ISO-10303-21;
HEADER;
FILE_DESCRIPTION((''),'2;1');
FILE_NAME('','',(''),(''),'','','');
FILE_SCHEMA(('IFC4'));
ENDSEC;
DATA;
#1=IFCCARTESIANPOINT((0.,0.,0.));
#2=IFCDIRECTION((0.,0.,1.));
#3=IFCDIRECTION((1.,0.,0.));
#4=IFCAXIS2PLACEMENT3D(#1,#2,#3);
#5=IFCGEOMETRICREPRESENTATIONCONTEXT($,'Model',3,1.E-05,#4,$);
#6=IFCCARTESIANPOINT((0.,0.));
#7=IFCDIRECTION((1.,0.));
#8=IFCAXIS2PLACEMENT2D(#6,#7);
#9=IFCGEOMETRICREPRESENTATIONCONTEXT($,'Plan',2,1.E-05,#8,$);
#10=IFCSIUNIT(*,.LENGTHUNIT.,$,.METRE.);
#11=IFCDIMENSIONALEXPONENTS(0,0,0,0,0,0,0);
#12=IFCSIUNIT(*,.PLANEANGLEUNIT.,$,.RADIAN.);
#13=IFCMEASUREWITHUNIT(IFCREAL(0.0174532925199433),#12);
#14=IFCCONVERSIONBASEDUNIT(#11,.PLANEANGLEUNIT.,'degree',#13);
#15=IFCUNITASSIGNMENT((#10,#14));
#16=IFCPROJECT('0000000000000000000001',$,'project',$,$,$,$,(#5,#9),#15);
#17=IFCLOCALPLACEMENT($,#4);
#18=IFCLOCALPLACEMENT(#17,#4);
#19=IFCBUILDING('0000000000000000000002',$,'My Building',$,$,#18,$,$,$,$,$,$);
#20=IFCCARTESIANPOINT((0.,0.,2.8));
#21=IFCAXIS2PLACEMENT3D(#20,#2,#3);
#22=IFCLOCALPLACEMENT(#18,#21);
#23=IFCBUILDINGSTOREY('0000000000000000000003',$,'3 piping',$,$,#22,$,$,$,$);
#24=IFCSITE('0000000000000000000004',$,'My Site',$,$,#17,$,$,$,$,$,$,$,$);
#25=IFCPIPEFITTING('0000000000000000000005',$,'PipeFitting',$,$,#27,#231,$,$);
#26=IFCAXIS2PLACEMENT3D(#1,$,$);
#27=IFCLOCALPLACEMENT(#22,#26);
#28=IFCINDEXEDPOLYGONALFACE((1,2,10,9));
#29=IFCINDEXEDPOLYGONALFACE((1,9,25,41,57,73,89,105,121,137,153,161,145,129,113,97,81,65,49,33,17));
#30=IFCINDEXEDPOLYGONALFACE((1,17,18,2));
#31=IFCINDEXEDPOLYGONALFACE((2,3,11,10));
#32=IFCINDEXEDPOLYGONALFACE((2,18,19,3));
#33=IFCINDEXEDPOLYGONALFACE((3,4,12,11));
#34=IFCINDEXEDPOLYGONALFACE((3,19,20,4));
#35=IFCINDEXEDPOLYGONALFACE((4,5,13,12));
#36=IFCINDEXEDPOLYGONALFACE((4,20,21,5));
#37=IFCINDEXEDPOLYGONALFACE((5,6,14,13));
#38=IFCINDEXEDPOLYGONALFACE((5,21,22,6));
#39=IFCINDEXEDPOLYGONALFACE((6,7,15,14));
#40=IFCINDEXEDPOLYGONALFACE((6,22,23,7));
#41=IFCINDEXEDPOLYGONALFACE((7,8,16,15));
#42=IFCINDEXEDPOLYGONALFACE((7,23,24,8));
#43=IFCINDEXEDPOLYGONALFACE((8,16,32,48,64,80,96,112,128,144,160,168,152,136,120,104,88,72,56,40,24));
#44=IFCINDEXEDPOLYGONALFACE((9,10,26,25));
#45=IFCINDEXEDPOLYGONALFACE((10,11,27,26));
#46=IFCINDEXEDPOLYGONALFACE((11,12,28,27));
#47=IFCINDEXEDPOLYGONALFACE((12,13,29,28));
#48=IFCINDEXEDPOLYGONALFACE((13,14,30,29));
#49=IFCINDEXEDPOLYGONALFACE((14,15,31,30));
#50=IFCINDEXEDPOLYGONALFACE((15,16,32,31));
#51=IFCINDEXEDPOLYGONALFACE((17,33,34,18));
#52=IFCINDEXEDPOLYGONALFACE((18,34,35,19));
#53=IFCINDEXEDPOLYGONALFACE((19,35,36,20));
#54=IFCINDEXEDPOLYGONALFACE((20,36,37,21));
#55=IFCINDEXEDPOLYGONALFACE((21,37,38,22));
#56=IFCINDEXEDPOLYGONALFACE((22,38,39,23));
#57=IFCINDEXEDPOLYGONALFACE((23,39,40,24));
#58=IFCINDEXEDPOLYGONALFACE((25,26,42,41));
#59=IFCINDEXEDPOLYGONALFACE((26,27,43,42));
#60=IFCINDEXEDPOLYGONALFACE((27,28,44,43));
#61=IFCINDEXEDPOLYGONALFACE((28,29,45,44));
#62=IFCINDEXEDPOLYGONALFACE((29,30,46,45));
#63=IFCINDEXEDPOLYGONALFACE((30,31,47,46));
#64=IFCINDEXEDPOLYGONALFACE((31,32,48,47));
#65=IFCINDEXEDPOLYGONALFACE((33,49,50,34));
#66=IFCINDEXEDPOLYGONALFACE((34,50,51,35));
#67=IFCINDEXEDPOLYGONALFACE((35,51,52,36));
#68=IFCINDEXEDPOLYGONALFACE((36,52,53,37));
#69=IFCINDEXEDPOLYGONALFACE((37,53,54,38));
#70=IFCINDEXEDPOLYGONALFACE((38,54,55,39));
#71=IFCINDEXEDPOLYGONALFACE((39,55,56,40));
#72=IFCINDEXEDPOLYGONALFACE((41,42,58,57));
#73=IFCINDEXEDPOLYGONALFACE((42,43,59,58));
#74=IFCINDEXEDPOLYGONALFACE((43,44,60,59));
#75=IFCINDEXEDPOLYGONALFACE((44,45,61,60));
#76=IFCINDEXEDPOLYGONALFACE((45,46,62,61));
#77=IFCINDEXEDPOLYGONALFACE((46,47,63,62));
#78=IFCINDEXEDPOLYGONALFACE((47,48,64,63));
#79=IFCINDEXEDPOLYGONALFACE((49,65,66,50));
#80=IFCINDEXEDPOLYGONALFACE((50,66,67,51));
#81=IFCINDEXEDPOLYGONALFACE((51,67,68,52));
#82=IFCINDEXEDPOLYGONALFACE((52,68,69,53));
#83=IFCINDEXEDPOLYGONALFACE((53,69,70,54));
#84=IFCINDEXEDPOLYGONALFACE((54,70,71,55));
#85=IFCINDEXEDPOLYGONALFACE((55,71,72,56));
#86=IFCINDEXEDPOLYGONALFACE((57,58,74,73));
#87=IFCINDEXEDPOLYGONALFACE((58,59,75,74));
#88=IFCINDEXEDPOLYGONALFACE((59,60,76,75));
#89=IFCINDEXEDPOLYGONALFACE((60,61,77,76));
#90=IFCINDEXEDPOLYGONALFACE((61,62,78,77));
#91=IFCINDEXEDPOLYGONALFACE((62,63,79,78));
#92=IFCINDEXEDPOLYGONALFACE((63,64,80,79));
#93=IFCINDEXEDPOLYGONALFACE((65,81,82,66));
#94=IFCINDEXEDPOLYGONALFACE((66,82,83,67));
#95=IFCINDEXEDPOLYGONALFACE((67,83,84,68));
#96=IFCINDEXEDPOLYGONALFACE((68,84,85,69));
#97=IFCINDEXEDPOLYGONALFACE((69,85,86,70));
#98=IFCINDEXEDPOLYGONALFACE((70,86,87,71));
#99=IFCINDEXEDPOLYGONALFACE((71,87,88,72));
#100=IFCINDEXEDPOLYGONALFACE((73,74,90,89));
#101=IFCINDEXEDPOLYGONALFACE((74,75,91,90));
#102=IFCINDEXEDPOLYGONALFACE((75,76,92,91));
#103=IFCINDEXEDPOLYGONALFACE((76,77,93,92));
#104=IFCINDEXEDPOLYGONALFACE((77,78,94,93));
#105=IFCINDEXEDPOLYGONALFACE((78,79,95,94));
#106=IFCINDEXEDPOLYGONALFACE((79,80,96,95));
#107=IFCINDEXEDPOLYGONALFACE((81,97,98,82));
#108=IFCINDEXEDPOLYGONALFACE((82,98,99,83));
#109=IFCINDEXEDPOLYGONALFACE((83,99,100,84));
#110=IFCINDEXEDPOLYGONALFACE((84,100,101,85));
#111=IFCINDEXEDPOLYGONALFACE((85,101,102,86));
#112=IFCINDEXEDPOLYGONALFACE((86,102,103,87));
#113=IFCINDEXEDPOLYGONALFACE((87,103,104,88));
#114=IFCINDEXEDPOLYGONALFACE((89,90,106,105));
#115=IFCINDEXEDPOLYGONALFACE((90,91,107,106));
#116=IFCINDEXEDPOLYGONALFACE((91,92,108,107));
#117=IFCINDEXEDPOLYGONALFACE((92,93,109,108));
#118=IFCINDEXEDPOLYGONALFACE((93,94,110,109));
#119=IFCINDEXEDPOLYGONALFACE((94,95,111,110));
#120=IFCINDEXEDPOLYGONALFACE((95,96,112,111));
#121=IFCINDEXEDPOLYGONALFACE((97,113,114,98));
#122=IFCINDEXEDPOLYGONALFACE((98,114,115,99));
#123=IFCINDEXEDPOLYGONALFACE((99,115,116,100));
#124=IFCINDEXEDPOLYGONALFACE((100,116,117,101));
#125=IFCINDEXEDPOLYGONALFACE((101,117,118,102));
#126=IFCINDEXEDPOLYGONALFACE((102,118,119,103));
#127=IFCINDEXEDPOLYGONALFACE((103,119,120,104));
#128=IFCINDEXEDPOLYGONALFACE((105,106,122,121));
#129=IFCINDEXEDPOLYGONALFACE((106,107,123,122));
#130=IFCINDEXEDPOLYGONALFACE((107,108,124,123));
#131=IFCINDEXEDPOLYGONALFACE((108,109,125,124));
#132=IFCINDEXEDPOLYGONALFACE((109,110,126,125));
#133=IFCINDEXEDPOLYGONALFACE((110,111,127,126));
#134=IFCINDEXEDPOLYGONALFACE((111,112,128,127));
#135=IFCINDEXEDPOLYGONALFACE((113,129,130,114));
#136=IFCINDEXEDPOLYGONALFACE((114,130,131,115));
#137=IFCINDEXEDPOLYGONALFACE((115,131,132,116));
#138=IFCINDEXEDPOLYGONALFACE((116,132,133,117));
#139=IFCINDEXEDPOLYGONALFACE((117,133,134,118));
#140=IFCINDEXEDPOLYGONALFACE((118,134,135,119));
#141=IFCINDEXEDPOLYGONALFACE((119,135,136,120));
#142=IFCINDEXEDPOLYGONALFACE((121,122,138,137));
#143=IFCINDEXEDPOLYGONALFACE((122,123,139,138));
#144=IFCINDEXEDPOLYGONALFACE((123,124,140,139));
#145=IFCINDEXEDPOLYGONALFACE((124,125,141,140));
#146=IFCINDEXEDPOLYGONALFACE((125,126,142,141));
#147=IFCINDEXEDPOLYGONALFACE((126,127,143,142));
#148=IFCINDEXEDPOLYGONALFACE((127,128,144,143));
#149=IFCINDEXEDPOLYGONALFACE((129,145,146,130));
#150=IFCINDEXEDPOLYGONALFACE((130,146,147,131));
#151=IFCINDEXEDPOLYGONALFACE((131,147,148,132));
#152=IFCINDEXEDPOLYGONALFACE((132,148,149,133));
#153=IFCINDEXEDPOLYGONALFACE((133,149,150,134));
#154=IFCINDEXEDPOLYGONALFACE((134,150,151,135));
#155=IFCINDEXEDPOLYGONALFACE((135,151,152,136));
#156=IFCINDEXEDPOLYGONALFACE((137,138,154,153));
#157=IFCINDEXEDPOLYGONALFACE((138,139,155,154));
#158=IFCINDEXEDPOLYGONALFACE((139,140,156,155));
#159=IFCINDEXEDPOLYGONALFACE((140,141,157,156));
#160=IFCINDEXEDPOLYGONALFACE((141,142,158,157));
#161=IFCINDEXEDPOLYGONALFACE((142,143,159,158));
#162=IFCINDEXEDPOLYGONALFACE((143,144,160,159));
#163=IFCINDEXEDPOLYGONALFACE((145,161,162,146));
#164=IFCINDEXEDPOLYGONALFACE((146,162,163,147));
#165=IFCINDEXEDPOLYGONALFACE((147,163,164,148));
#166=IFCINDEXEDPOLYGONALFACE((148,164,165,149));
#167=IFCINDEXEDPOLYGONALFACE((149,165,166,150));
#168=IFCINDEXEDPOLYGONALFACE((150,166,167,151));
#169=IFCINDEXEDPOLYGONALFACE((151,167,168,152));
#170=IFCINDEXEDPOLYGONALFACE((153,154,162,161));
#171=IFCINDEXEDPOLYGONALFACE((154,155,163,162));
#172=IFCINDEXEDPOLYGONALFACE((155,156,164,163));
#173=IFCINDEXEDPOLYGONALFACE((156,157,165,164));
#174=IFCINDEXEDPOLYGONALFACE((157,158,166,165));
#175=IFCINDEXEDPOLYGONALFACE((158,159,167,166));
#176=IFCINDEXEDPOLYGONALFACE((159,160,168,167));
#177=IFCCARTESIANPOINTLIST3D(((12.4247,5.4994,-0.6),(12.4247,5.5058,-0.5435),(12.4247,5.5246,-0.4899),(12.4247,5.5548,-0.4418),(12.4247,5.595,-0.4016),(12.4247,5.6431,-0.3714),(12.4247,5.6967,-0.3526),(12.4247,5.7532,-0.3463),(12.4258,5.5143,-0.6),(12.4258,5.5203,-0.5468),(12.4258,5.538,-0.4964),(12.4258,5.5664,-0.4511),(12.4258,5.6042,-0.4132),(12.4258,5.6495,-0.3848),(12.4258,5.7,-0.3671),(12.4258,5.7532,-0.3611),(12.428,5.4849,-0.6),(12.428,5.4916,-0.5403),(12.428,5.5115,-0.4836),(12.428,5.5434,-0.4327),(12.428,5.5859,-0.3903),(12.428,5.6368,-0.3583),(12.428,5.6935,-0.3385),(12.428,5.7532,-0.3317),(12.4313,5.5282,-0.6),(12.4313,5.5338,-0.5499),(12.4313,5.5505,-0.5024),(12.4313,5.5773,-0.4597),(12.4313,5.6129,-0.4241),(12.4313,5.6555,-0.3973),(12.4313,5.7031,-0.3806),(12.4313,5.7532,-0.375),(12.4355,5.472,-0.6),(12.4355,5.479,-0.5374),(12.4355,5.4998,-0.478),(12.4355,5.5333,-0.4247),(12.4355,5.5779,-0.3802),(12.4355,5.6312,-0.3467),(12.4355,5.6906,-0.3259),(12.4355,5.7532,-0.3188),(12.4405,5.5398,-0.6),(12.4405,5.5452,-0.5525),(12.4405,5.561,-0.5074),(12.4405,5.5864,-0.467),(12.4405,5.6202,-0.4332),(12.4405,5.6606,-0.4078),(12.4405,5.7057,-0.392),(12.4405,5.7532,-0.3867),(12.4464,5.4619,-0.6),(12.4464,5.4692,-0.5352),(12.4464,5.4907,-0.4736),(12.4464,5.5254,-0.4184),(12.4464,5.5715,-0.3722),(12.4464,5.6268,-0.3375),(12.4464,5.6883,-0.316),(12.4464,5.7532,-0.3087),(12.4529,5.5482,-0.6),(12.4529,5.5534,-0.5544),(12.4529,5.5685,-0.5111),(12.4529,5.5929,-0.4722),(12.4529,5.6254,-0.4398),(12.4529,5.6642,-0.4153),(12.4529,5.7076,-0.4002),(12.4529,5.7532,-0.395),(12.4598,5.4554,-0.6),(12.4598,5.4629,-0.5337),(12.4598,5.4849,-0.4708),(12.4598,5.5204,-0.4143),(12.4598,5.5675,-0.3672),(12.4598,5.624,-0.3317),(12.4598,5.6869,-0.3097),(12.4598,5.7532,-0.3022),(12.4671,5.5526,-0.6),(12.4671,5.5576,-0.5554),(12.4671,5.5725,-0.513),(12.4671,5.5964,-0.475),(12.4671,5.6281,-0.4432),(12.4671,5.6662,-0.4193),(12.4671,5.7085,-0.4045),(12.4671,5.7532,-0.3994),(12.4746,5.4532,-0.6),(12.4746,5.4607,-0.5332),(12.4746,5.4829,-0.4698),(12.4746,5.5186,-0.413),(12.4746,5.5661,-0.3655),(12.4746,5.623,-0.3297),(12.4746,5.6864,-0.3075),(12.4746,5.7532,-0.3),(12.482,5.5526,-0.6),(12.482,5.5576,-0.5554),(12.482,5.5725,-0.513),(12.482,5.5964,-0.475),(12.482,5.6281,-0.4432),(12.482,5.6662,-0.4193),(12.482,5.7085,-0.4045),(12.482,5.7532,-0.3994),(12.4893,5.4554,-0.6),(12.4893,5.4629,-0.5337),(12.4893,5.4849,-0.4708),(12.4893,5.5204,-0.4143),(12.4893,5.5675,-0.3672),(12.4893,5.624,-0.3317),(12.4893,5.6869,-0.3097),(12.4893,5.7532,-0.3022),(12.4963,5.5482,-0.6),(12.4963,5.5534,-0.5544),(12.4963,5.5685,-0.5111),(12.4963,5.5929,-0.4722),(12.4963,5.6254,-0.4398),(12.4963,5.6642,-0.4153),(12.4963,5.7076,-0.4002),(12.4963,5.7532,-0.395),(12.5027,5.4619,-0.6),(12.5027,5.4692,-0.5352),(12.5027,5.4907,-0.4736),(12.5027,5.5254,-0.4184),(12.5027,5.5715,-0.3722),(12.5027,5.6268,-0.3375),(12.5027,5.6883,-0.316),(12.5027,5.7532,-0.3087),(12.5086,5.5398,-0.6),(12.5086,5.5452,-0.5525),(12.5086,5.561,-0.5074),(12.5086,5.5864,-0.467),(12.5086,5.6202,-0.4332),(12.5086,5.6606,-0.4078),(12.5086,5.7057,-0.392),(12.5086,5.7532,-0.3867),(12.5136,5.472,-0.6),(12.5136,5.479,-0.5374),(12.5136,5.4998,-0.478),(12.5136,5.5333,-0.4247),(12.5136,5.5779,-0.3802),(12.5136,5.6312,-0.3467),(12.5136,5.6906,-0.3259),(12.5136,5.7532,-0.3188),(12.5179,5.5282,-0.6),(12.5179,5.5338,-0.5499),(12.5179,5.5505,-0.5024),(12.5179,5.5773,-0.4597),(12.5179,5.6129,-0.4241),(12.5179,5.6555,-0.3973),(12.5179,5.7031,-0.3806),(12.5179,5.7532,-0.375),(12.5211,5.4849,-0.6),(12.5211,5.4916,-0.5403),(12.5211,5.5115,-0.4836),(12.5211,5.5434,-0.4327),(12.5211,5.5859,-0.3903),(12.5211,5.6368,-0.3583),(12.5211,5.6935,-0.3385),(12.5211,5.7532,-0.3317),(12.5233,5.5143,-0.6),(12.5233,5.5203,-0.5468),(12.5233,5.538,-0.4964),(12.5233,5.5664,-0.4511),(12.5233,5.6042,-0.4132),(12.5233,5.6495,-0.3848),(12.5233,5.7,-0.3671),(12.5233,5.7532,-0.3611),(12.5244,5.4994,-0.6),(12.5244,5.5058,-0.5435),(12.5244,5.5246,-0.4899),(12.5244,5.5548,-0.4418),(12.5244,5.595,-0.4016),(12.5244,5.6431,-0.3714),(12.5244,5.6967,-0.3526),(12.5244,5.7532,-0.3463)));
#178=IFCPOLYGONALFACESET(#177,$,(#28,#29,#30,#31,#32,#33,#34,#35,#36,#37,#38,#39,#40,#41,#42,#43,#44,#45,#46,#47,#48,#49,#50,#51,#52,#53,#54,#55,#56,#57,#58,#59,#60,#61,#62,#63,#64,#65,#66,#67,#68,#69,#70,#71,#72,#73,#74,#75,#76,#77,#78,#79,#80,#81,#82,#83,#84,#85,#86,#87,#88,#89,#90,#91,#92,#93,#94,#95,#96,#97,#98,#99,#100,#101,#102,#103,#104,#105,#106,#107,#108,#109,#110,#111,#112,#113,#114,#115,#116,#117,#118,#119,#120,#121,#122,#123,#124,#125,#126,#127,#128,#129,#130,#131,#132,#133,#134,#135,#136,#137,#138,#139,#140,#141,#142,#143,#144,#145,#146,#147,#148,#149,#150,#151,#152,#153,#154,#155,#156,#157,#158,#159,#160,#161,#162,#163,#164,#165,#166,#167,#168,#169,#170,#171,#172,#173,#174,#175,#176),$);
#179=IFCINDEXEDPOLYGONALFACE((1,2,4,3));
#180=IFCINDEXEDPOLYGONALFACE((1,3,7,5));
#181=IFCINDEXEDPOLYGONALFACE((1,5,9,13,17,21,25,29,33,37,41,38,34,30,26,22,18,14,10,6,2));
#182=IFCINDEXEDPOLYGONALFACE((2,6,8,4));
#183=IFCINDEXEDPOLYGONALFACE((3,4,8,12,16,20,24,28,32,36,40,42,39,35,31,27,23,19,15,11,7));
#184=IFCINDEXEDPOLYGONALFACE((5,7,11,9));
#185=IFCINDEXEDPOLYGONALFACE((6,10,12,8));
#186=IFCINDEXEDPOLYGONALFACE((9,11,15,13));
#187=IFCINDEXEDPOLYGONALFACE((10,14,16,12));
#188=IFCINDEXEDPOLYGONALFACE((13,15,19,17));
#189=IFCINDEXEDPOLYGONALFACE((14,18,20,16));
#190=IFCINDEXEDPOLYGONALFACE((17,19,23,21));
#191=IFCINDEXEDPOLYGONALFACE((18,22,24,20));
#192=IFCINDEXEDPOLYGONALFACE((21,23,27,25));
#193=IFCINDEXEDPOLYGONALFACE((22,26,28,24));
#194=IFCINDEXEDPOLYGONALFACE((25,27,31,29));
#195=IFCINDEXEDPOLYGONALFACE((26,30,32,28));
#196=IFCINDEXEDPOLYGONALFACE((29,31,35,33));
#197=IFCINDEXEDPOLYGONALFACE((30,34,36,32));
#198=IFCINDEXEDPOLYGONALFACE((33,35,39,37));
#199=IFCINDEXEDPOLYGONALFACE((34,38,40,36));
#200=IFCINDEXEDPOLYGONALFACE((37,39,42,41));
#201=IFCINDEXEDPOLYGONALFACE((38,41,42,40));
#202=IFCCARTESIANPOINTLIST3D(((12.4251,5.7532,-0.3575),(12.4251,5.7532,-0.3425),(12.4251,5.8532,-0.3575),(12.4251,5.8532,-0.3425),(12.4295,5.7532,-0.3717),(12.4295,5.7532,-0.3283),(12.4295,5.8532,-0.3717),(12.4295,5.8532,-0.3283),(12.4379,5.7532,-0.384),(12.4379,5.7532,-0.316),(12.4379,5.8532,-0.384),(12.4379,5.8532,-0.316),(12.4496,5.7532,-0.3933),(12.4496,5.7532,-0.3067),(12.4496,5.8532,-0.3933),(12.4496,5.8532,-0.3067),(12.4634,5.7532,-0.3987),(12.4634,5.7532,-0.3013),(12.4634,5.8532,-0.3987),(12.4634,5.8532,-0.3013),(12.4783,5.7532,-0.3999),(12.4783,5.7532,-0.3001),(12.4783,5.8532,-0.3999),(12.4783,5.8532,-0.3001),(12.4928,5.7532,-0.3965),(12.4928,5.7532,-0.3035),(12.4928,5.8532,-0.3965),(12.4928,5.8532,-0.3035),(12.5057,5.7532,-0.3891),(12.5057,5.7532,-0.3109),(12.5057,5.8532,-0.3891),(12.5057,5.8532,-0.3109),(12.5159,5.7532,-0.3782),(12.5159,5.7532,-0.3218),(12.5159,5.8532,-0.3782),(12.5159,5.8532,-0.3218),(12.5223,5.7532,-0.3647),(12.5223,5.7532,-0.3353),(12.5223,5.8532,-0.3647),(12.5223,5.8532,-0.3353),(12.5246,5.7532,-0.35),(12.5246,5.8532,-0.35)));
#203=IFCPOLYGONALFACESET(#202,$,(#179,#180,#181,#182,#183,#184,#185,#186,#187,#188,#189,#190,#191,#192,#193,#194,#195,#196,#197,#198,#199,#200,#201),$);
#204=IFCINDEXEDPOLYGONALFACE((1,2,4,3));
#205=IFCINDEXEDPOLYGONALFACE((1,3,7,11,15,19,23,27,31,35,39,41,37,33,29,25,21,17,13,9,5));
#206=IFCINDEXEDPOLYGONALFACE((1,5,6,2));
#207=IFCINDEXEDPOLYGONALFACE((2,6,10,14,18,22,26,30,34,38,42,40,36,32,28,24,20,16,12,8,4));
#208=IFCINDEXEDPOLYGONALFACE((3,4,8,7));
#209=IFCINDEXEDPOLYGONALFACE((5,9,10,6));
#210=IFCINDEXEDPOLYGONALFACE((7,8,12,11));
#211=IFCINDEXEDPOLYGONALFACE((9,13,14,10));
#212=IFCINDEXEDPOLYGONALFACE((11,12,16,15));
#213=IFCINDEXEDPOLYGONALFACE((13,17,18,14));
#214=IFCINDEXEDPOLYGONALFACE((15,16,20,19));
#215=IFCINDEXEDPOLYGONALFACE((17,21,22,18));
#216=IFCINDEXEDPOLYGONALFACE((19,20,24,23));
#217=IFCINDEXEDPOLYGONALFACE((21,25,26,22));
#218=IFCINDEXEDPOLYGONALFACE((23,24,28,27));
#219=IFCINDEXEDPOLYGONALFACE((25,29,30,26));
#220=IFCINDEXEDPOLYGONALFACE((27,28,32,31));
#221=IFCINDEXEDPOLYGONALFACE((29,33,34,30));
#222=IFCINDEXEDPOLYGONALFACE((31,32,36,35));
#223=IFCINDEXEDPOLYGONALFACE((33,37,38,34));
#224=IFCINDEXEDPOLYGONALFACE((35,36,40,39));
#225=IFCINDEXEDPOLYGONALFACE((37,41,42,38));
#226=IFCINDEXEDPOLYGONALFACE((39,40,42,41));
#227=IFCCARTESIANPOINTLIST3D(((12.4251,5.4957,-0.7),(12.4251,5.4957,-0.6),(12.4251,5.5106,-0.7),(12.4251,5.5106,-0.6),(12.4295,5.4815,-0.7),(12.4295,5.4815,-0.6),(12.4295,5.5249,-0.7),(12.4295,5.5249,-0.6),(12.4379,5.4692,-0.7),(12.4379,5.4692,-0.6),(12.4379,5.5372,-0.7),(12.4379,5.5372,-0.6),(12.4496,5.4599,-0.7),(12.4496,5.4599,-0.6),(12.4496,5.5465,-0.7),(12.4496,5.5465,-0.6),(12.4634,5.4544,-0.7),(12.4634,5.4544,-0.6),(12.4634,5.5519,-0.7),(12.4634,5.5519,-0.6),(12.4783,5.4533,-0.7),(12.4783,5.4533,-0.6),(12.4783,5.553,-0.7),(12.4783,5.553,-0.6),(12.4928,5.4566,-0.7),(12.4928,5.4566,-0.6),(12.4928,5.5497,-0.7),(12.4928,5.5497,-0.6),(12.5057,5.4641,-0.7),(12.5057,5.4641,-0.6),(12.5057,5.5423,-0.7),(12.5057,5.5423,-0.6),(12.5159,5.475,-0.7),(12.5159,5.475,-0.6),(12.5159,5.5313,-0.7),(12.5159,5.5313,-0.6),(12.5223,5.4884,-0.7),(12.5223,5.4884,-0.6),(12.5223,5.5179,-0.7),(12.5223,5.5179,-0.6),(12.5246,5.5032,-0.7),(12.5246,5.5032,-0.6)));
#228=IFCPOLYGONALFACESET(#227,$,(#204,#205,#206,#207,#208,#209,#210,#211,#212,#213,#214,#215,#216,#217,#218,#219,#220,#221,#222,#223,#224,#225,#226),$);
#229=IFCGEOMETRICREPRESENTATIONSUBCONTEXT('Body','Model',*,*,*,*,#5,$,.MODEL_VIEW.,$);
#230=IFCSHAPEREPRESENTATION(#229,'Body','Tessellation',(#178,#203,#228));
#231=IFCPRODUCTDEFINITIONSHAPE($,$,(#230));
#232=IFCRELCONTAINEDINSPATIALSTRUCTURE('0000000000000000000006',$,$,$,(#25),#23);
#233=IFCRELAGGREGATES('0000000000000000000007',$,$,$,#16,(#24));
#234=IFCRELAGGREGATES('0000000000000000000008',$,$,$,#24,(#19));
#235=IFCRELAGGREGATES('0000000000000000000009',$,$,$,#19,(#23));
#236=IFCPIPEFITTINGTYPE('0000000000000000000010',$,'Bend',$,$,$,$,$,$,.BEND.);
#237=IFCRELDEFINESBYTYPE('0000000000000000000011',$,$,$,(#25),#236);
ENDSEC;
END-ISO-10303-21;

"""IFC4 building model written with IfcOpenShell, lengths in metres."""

from ifc_helpers import new_model, entity, si_unit, converted_unit, frame, origin_with_axes, origin_2d_with_axis, place, context, subcontext, project, spatial, circle, extrude, source, transform, mapped, type_object, type_shapes, element, save


model = new_model("IFC4")

# Units and contexts
model_context = context("Model", 3, precision=1e-05, world=origin_with_axes())
plan_context = context("Plan", 2, precision=1e-05, world=origin_2d_with_axis())
body_context = subcontext(model_context, "Body", "Model", "MODEL_VIEW")
ifc_project = project(units=[si_unit("LENGTHUNIT", "METRE"), converted_unit("PLANEANGLEUNIT", "degree", entity("IfcReal", 0.0174532925199433), si_unit("PLANEANGLEUNIT", "RADIAN"), dimensions=[0, 0, 0, 0, 0, 0, 0])], contexts=[model_context, plan_context])

# Site, building, storey
site_placement = place(None, origin_with_axes())
site = spatial("IfcSite", under=ifc_project, at=site_placement, Name="My Site")
building_placement = place(site_placement, origin_with_axes())
building = spatial("IfcBuilding", under=site, at=building_placement, Name="My Building")
storey_placement = place(building_placement, frame((0.0, 0.0, 2.8), z_axis=(0.0, 0.0, 1.0), x_axis=(1.0, 0.0, 0.0)))
storey = spatial("IfcBuildingStorey", under=building, at=storey_placement, Name="3 piping")

# Pipe fitting
pipe_fitting_type_1 = type_object("IfcPipeFittingType", Name="Bend", PredefinedType="BEND")
shared_shape = source(origin_with_axes(), body_context, "Body", "SolidModel", [
    entity("IfcSweptDiskSolid", entity("IfcIndexedPolyCurve", entity("IfcCartesianPointList3D", [[0.0, 0.0, 0.1], [0.0, -0.0732, 0.2768], [0.0, -0.25, 0.35]]), [entity("IfcArcIndex", [1, 2, 3])]), 0.05),
    extrude(circle(Radius=0.05), origin_with_axes(), (0.0, 0.0, 1.0), 0.1),
    extrude(circle(Radius=0.05), frame((0.0, -0.25, 0.35), z_axis=(0.0, -1.0, 0.0), x_axis=(1.0, 0.0, 0.0)), (0.0, 0.0, 1.0), 0.1),
])
type_shapes(pipe_fitting_type_1, [shared_shape])
for number, where, z_axis, x_axis, name in (
    (1, (12.4746, 5.8532, -0.35), (0.0, -1.0, 0.0), (1.0, 0.0, 0.0), "PipeFitting"),
):
    element("IfcPipeFitting", number, at=place(storey_placement, frame(where, z_axis=z_axis, x_axis=x_axis)), inside=storey, type_object=pipe_fitting_type_1, Name=name, context=body_context, shape_type="MappedRepresentation", body=[
        mapped(shared_shape, transform((0.0, 0.0, 0.0), x_axis=(1.0, 0.0, 0.0), y_axis=(0.0, 1.0, 0.0), z_axis=(0.0, 0.0, 1.0), scale=1.0)),
    ])

save(model, "model.ifc")
